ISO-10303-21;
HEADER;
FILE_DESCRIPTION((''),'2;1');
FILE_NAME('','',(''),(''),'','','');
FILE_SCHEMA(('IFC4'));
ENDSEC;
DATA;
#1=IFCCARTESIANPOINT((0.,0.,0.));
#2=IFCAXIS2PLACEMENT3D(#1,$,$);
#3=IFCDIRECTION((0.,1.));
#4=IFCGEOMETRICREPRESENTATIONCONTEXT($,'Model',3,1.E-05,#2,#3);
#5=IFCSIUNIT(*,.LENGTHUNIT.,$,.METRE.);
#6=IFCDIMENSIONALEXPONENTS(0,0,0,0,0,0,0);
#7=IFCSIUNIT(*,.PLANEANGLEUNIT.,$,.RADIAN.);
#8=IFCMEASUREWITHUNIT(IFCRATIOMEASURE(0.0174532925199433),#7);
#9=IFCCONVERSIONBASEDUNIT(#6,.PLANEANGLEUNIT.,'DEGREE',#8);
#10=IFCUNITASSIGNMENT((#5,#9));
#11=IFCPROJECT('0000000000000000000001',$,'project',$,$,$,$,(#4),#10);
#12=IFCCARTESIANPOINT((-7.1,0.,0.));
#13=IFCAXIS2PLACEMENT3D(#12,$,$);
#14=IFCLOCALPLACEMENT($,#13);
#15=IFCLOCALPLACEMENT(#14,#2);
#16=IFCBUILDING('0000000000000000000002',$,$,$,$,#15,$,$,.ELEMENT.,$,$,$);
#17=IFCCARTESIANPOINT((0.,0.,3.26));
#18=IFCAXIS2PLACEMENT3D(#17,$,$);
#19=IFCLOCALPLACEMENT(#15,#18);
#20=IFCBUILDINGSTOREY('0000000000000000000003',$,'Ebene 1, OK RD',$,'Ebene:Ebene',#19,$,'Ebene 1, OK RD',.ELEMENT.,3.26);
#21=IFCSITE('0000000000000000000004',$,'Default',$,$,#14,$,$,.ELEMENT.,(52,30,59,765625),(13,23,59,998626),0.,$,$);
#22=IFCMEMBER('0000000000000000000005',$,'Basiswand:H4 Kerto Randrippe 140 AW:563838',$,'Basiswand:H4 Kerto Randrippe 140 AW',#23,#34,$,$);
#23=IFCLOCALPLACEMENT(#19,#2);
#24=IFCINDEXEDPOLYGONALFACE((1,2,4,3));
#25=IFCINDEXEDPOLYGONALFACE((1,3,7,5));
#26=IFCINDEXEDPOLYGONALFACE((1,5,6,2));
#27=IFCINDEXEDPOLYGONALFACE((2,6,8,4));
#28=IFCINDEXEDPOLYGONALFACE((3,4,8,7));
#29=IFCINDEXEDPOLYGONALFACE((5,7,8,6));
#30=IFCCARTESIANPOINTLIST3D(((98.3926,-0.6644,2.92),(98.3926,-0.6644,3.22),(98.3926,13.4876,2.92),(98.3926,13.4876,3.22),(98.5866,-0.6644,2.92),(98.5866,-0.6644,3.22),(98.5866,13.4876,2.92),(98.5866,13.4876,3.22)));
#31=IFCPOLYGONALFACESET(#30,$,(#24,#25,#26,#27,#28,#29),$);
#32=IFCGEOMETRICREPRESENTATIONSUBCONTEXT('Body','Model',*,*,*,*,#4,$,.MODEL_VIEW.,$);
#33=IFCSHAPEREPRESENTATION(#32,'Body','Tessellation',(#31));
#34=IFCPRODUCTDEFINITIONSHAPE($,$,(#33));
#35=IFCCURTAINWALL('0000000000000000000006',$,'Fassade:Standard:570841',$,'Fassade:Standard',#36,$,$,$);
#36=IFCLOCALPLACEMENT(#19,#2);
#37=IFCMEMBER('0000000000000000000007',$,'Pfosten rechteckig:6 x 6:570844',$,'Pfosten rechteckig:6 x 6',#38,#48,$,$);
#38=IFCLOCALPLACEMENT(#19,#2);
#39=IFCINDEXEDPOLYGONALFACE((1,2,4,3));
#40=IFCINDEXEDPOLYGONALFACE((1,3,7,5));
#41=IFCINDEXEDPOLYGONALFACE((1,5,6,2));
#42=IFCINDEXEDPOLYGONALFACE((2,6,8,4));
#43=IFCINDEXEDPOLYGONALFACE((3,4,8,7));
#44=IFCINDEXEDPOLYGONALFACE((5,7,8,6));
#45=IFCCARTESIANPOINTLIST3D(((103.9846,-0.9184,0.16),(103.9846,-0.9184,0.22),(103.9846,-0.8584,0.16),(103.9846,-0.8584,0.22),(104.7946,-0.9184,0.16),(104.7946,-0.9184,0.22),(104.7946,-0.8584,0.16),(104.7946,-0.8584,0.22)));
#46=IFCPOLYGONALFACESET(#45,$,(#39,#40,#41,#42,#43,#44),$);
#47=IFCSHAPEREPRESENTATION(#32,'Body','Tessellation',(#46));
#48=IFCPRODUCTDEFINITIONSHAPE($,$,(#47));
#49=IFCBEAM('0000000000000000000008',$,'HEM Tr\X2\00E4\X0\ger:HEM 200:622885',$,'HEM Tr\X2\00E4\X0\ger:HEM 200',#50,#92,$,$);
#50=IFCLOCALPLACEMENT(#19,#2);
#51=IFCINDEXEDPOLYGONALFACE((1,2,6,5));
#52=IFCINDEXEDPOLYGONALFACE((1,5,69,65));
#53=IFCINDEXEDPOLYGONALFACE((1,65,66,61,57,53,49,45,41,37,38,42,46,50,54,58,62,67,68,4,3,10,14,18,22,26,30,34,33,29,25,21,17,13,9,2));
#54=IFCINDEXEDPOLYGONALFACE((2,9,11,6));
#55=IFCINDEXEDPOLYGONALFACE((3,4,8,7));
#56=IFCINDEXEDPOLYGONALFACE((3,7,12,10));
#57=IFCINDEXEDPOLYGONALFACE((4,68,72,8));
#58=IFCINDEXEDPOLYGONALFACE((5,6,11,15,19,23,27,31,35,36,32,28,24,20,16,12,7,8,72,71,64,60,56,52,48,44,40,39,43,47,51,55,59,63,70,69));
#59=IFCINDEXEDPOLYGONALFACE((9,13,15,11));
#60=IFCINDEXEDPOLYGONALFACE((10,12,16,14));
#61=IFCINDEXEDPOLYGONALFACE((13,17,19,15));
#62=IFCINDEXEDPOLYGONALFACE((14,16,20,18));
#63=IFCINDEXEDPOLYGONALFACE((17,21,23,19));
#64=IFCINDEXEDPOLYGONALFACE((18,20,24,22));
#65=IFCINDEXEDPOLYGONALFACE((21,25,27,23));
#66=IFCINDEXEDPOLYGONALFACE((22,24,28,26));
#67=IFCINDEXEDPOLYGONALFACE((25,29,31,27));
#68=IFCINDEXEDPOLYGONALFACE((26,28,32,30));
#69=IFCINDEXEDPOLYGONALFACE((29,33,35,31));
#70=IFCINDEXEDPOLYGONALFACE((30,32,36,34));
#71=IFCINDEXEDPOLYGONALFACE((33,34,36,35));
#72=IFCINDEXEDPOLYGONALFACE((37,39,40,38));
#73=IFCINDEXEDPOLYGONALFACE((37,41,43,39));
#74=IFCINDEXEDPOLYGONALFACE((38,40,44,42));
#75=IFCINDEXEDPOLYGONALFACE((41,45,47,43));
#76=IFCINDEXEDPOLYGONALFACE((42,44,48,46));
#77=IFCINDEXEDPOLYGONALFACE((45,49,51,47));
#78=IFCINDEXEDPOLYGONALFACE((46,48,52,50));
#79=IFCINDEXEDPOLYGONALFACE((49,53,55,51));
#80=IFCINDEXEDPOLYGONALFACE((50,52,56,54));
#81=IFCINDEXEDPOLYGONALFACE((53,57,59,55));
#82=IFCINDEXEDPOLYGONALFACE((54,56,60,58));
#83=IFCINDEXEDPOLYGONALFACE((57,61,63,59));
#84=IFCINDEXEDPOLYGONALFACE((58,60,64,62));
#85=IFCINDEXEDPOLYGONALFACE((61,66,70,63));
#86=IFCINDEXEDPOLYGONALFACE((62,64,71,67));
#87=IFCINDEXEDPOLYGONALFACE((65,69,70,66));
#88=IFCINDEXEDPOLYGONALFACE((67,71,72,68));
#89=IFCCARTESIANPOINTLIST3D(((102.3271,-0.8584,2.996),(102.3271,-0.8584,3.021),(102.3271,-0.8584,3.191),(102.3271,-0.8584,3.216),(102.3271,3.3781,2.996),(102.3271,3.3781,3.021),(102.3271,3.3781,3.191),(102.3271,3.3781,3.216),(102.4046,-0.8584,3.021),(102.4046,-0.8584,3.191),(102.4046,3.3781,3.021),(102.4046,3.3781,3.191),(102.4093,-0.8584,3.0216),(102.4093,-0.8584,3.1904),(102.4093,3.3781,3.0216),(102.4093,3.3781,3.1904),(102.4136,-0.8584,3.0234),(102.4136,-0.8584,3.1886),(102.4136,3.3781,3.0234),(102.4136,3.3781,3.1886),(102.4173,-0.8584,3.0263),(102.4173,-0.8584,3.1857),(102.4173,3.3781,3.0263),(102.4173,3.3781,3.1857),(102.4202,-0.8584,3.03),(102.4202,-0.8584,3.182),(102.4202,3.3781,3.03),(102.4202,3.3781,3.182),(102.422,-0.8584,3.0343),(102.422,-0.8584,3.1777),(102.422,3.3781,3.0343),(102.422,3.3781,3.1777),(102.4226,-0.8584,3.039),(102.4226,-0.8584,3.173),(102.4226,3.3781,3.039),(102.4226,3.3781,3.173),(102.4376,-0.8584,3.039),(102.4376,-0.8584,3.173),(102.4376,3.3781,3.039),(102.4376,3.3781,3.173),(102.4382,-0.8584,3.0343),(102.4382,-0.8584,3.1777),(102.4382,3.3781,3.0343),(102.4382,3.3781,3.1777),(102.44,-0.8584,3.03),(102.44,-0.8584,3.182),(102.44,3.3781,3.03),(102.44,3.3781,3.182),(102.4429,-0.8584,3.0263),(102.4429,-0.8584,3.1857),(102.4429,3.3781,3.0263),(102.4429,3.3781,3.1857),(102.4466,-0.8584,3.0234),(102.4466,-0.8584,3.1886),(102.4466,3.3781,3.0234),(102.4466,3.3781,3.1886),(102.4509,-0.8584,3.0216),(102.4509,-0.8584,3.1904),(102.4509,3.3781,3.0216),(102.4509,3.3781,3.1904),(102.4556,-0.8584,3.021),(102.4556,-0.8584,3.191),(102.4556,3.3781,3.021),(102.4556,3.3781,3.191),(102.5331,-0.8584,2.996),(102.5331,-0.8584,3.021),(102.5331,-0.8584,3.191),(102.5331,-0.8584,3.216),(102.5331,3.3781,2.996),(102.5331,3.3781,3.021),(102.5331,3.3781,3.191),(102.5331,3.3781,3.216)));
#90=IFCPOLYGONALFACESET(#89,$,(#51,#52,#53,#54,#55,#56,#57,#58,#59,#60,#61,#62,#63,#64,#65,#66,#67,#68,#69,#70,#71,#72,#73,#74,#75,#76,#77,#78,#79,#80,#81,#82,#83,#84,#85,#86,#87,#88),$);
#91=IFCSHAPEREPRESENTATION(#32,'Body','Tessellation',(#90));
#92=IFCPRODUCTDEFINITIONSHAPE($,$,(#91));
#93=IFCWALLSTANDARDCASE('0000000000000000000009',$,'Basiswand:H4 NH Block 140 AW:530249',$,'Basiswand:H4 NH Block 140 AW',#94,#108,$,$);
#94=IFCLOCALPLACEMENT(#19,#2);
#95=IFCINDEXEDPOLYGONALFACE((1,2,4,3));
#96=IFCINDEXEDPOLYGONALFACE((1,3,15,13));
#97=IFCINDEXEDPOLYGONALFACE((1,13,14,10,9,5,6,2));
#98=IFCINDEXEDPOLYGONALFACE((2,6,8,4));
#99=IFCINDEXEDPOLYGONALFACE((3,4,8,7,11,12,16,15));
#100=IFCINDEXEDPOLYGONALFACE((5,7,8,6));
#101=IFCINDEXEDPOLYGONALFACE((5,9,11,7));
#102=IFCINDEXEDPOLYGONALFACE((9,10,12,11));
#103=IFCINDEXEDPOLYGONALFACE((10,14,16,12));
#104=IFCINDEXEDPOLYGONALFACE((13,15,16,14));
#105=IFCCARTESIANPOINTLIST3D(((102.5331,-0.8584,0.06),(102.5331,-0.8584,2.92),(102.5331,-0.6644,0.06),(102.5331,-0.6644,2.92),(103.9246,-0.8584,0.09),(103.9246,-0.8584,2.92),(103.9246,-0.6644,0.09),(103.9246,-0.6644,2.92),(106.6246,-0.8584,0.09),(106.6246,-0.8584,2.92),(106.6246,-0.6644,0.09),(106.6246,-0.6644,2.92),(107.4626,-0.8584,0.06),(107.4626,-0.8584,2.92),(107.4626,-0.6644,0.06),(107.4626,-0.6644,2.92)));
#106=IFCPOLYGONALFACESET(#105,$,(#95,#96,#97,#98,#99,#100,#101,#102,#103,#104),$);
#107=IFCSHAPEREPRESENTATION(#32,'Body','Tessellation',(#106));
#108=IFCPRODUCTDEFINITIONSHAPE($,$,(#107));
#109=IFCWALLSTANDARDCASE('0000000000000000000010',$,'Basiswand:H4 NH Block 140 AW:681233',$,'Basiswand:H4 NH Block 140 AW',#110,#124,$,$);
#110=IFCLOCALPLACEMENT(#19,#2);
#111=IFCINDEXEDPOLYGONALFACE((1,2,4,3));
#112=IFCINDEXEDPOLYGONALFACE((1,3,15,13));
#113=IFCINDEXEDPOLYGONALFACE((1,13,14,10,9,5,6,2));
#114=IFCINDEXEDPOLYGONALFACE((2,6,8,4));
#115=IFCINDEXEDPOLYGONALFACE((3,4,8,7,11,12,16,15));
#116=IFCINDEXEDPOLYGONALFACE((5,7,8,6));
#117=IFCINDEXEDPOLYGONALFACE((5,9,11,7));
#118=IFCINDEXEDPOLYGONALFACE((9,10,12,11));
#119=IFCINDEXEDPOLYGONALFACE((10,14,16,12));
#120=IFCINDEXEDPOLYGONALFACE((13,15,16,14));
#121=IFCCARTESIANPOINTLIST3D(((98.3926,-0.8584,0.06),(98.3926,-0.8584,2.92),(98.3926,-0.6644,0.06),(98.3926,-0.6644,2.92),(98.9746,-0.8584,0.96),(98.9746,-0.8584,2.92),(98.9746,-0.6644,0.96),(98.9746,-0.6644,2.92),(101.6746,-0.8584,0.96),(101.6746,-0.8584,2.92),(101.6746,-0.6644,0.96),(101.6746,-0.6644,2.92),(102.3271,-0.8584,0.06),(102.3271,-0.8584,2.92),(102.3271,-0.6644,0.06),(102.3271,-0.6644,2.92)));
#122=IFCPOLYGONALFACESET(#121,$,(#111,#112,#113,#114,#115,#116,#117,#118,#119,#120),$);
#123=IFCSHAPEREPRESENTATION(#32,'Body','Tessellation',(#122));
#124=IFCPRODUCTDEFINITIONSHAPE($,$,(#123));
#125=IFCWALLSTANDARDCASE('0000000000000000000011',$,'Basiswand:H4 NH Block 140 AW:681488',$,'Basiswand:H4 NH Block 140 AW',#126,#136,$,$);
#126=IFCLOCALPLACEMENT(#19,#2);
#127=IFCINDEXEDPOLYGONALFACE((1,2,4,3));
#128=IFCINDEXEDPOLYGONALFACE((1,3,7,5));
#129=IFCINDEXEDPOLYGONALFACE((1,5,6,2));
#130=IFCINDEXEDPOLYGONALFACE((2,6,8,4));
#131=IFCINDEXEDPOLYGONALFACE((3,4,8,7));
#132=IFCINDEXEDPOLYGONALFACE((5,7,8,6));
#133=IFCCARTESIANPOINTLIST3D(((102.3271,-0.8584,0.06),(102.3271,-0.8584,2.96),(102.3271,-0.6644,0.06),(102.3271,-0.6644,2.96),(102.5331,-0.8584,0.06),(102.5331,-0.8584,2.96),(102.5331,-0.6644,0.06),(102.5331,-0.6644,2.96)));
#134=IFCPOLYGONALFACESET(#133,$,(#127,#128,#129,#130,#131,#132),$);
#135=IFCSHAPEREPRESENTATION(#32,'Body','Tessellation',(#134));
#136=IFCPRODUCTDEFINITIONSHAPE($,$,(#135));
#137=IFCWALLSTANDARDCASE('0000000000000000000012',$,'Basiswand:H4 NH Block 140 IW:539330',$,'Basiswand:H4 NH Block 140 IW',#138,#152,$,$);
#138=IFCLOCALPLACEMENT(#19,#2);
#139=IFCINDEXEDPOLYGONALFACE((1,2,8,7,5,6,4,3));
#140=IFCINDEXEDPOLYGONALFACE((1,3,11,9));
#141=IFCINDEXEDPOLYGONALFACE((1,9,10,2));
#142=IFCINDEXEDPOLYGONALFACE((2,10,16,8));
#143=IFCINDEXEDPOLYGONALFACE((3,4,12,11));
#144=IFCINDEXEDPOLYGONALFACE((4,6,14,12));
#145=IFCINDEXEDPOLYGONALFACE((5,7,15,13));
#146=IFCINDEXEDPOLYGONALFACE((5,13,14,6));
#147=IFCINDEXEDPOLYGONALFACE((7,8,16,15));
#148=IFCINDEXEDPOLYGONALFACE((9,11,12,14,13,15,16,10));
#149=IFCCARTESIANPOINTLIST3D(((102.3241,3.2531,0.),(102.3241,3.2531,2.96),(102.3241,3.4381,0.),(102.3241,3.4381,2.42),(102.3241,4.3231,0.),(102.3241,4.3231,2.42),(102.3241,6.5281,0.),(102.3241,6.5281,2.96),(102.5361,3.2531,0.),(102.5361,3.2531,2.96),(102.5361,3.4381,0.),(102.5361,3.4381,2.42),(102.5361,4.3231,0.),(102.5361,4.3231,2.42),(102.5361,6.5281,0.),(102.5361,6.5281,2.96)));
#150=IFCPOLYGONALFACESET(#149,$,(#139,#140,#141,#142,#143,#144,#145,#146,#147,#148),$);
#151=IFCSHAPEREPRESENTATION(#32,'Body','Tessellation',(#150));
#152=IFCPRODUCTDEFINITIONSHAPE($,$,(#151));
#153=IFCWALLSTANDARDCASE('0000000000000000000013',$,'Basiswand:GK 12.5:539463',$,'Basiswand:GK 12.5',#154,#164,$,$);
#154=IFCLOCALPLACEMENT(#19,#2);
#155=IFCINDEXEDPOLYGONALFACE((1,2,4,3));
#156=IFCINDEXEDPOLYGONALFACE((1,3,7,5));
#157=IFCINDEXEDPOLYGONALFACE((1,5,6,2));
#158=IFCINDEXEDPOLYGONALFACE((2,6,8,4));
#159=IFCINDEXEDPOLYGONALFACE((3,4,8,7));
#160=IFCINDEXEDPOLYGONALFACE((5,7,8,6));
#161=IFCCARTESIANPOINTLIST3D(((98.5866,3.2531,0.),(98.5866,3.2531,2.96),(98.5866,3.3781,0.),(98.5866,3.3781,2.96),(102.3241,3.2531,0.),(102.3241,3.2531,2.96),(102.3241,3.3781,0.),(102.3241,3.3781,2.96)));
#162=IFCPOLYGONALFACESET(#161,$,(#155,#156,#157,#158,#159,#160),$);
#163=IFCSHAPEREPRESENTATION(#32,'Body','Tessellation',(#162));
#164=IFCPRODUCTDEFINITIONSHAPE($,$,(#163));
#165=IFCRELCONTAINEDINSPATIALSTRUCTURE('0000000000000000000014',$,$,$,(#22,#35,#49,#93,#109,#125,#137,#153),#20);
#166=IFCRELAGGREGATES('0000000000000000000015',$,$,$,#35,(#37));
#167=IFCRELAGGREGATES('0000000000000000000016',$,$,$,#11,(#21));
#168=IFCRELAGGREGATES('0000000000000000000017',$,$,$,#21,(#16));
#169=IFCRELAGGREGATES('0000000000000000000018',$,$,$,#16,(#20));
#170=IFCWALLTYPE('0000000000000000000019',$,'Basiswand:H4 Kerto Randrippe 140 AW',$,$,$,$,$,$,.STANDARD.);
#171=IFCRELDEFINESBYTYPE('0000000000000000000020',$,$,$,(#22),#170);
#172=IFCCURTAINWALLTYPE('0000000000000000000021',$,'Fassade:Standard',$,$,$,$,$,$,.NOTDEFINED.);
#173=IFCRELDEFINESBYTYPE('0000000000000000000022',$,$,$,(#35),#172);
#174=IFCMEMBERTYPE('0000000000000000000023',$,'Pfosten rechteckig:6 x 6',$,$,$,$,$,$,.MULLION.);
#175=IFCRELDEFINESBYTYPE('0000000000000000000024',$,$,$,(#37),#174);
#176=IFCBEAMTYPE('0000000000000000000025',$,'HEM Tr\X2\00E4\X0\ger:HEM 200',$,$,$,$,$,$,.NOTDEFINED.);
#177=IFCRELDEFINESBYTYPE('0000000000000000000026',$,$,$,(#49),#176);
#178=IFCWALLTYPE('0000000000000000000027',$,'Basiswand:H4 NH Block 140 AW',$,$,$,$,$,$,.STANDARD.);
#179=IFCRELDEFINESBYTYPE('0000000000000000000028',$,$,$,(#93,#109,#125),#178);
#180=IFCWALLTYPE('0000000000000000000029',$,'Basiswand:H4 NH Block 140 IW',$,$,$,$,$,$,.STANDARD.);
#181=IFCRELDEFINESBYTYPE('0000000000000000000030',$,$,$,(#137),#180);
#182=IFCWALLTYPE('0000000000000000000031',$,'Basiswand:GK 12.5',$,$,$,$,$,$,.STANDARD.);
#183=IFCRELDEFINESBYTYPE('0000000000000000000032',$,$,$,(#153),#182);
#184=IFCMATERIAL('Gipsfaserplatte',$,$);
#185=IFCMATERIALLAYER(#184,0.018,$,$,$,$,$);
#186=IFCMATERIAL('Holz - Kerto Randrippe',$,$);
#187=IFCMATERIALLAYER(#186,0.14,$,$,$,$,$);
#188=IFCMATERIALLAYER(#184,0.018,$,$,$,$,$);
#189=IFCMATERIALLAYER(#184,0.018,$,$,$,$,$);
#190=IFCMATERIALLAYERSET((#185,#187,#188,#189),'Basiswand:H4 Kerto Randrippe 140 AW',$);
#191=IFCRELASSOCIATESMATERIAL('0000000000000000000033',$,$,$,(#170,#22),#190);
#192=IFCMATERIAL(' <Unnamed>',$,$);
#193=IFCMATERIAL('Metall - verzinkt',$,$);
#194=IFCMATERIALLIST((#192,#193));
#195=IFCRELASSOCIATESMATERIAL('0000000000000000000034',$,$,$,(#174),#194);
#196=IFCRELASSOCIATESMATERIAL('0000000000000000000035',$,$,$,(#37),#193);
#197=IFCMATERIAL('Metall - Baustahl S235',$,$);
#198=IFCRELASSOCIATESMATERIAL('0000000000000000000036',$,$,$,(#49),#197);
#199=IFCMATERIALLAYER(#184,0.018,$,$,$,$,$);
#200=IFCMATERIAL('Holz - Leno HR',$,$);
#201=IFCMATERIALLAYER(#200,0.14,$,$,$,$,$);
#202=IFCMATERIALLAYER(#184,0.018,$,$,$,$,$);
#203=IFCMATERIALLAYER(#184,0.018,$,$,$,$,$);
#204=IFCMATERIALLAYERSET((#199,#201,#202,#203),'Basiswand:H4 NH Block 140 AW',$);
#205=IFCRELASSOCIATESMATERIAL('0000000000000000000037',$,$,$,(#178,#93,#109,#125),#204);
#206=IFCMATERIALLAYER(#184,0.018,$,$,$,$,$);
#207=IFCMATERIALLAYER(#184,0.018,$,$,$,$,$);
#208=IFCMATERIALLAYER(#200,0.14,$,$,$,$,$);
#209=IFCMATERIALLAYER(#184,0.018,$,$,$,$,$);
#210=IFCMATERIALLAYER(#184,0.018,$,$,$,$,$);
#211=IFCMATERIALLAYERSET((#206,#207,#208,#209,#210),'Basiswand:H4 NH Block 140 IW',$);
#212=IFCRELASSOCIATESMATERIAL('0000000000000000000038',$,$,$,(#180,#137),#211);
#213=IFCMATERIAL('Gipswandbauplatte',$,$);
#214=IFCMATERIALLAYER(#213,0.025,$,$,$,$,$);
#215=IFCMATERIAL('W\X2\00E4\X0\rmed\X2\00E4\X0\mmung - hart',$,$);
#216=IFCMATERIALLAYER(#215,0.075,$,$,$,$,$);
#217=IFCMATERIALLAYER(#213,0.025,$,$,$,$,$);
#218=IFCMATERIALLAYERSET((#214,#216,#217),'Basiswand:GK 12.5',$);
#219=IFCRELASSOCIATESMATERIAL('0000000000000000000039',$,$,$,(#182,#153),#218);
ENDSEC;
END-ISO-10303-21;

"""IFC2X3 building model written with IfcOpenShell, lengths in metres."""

from ifc_helpers import new_model, entity, si_unit, converted_unit, direction, frame, frame_2d, origin, origin_2d_with_axis, place, context, subcontext, project, spatial, rectangle, i_section, extrude, source, transform, mapped, material, material_list, layer, layer_set, layer_usage, type_object, type_shapes, element, aggregate, save


model = new_model("IFC2X3")

# Units and contexts
model_context = context("Model", 3, precision=1e-05, world=origin(), true_north=direction((0.0, 1.0)))
body_context = subcontext(model_context, "Body", "Model", "MODEL_VIEW")
ifc_project = project(units=[si_unit("LENGTHUNIT", "METRE"), converted_unit("PLANEANGLEUNIT", "DEGREE", entity("IfcRatioMeasure", 0.0174532925199433), si_unit("PLANEANGLEUNIT", "RADIAN"), dimensions=[0, 0, 0, 0, 0, 0, 0])], contexts=[model_context])

# Site, building, storey
site_placement = place(None, frame((-7.1, 0.0, 0.0)))
site = spatial("IfcSite", under=ifc_project, at=site_placement, Name="Default", CompositionType="ELEMENT", RefLatitude=(52, 30, 59, 765625), RefLongitude=(13, 23, 59, 998626), RefElevation=0.0)
building_placement = place(site_placement, origin())
building = spatial("IfcBuilding", under=site, at=building_placement, CompositionType="ELEMENT")
storey_placement = place(building_placement, frame((0.0, 0.0, 3.26)))
storey = spatial("IfcBuildingStorey", under=building, at=storey_placement, Name="Ebene 1, OK RD", ObjectType="Ebene:Ebene", LongName="Ebene 1, OK RD", CompositionType="ELEMENT", Elevation=3.26)

# Member
ifc_material_1 = material(Name="Gipsfaserplatte")
ifc_layer_1 = layer(ifc_material_1, 0.018)
ifc_material_2 = material(Name="Holz - Kerto Randrippe")
ifc_layer_2 = layer(ifc_material_2, 0.14)
ifc_layer_3 = layer(ifc_material_1, 0.018)
ifc_layer_4 = layer(ifc_material_1, 0.018)
ifc_layer_set_1 = layer_set([ifc_layer_1, ifc_layer_2, ifc_layer_3, ifc_layer_4], Name="Basiswand:H4 Kerto Randrippe 140 AW")
ifc_layer_usage_1 = layer_usage(ifc_layer_set_1, "AXIS2", "NEGATIVE", 0.097)
wall_type_1 = type_object("IfcWallType", Name="Basiswand:H4 Kerto Randrippe 140 AW", PredefinedType="STANDARD", material=ifc_layer_set_1)
member_1_placement = place(storey_placement, frame((98.4896, -0.6644, 2.92), z_axis=(0.0, 0.0, 1.0), x_axis=(0.0, 1.0, 0.0)))
element("IfcMember", 1, at=member_1_placement, inside=storey, type_object=wall_type_1, material=ifc_layer_usage_1, Name="Basiswand:H4 Kerto Randrippe 140 AW:563838", ObjectType="Basiswand:H4 Kerto Randrippe 140 AW", context=body_context, shape_type="SweptSolid", body=[
    extrude(rectangle(XDim=14.152, YDim=0.194, at=frame_2d((7.076, 0.0), x_axis=(-1.0, 0.0))), origin(), (0.0, 0.0, 1.0), 0.3),
])

# Curtain wall, member
curtain_wall_type = type_object("IfcCurtainWallType", Name="Fassade:Standard", PredefinedType="NOTDEFINED")
curtain_wall_placement = place(storey_placement, frame((0.0, 0.0, -3.26)))
curtain_wall = element("IfcCurtainWall", 2, at=curtain_wall_placement, inside=storey, type_object=curtain_wall_type, Name="Fassade:Standard:570841", ObjectType="Fassade:Standard")
ifc_material_3 = material(Name="Metall - verzinkt")
ifc_material_4 = material(Name=" <Unnamed>")
ifc_material_list = material_list([ifc_material_4, ifc_material_3])
member_type = type_object("IfcMemberType", Name="Pfosten rechteckig:6 x 6", PredefinedType="MULLION", material=ifc_material_list)
shared_shape = source(origin(), body_context, "Body", "SweptSolid", [
    extrude(rectangle(XDim=0.06, YDim=0.06, at=origin_2d_with_axis()), frame((-0.03, 0.0, -0.81), z_axis=(0.0, 0.0, 1.0), x_axis=(0.0, -1.0, 0.0)), (0.0, 0.0, 1.0), 0.81),
])
type_shapes(member_type, [shared_shape])
member_2_placement = place(storey_placement, frame((103.9846, -0.8884, 0.16), z_axis=(-1.0, 0.0, 0.0), x_axis=(0.0, 0.0, -1.0)))
member_2 = element("IfcMember", 3, at=member_2_placement, type_object=member_type, material=ifc_material_3, Name="Pfosten rechteckig:6 x 6:570844", ObjectType="Pfosten rechteckig:6 x 6", context=body_context, shape_type="MappedRepresentation", body=[
    mapped(shared_shape, transform((0.0, 0.0, 0.0), scale=1.0)),
])
aggregate(curtain_wall, [member_2])

# Beam
ifc_material_5 = material(Name="Metall - Baustahl S235")
beam_type = type_object("IfcBeamType", Name="HEM Träger:HEM 200", PredefinedType="NOTDEFINED")
beam_placement = place(storey_placement, frame((102.4301, -0.8404, 2.996), z_axis=(0.0, 0.0, 1.0), x_axis=(0.0, 1.0, 0.0)))
element("IfcBeam", 4, at=beam_placement, inside=storey, type_object=beam_type, material=ifc_material_5, Name="HEM Träger:HEM 200:622885", ObjectType="HEM Träger:HEM 200", context=body_context, shape_type="SweptSolid", body=[
    extrude(i_section(OverallWidth=0.206, OverallDepth=0.22, WebThickness=0.015, FlangeThickness=0.025, FilletRadius=0.018, at=frame_2d((0.0, 0.0), x_axis=(0.0, 1.0))), frame((-0.018, 0.0, 0.11), z_axis=(1.0, 0.0, 0.0), x_axis=(0.0, 0.0, -1.0)), (0.0, 0.0, 1.0), 4.2365),
])

# Walls, openings
ifc_layer_5 = layer(ifc_material_1, 0.018)
ifc_material_6 = material(Name="Holz - Leno HR")
ifc_layer_6 = layer(ifc_material_6, 0.14)
ifc_layer_7 = layer(ifc_material_1, 0.018)
ifc_layer_8 = layer(ifc_material_1, 0.018)
ifc_layer_set_2 = layer_set([ifc_layer_5, ifc_layer_6, ifc_layer_7, ifc_layer_8], Name="Basiswand:H4 NH Block 140 AW")
ifc_layer_usage_2 = layer_usage(ifc_layer_set_2, "AXIS2", "NEGATIVE", 0.097)
wall_type_2 = type_object("IfcWallType", Name="Basiswand:H4 NH Block 140 AW", PredefinedType="STANDARD", material=ifc_layer_set_2)
wall_1_placement = place(storey_placement, frame((107.4626, -0.7614, 0.06), z_axis=(0.0, 0.0, 1.0), x_axis=(-1.0, 0.0, 0.0)))
wall_1 = element("IfcWallStandardCase", 5, at=wall_1_placement, inside=storey, type_object=wall_type_2, material=ifc_layer_usage_2, Name="Basiswand:H4 NH Block 140 AW:530249", ObjectType="Basiswand:H4 NH Block 140 AW", context=body_context, shape_type="SweptSolid", body=[
    extrude(rectangle(XDim=4.9295, YDim=0.194, at=frame_2d((2.4648, 0.0), x_axis=(-1.0, 0.0))), origin(), (0.0, 0.0, 1.0), 2.86),
])
opening_1_placement = place(wall_1_placement, origin())
element("IfcOpeningElement", 6, at=opening_1_placement, cuts=wall_1, ObjectType="Opening", context=body_context, shape_type="SweptSolid", body=[
    extrude(rectangle(XDim=2.87, YDim=2.7, at=frame_2d((0.0, 0.0), x_axis=(1.0, 0.0))), frame((2.188, -0.097, 1.465), z_axis=(0.0, 1.0, 0.0), x_axis=(0.0, 0.0, -1.0)), (0.0, 0.0, 1.0), 0.194),
])
ifc_layer_usage_3 = layer_usage(ifc_layer_set_2, "AXIS2", "NEGATIVE", 0.097)
wall_2_placement = place(storey_placement, frame((102.3271, -0.7614, 0.06), z_axis=(0.0, 0.0, 1.0), x_axis=(-1.0, 0.0, 0.0)))
wall_2 = element("IfcWallStandardCase", 7, at=wall_2_placement, inside=storey, type_object=wall_type_2, material=ifc_layer_usage_3, Name="Basiswand:H4 NH Block 140 AW:681233", ObjectType="Basiswand:H4 NH Block 140 AW", context=body_context, shape_type="SweptSolid", body=[
    extrude(rectangle(XDim=3.9345, YDim=0.194, at=frame_2d((1.9673, 0.0), x_axis=(-1.0, 0.0))), origin(), (0.0, 0.0, 1.0), 2.86),
])
opening_2_placement = place(wall_2_placement, origin())
element("IfcOpeningElement", 8, at=opening_2_placement, cuts=wall_2, ObjectType="Opening", context=body_context, shape_type="SweptSolid", body=[
    extrude(rectangle(XDim=2.0, YDim=2.7, at=origin_2d_with_axis()), frame((2.0025, -0.097, 1.9), z_axis=(0.0, 1.0, 0.0), x_axis=(0.0, 0.0, -1.0)), (0.0, 0.0, 1.0), 0.194),
])

# Wall
ifc_layer_usage_4 = layer_usage(ifc_layer_set_2, "AXIS2", "NEGATIVE", 0.097)
wall_3_placement = place(storey_placement, frame((102.5331, -0.7614, 0.06), z_axis=(0.0, 0.0, 1.0), x_axis=(-1.0, 0.0, 0.0)))
element("IfcWallStandardCase", 9, at=wall_3_placement, inside=storey, type_object=wall_type_2, material=ifc_layer_usage_4, Name="Basiswand:H4 NH Block 140 AW:681488", ObjectType="Basiswand:H4 NH Block 140 AW", context=body_context, shape_type="SweptSolid", body=[
    extrude(rectangle(XDim=0.206, YDim=0.194, at=frame_2d((0.103, 0.0), x_axis=(-1.0, 0.0))), origin(), (0.0, 0.0, 1.0), 2.9),
])

# Wall, opening
ifc_layer_9 = layer(ifc_material_1, 0.018)
ifc_layer_10 = layer(ifc_material_1, 0.018)
ifc_layer_11 = layer(ifc_material_6, 0.14)
ifc_layer_12 = layer(ifc_material_1, 0.018)
ifc_layer_13 = layer(ifc_material_1, 0.018)
ifc_layer_set_3 = layer_set([ifc_layer_9, ifc_layer_10, ifc_layer_11, ifc_layer_12, ifc_layer_13], Name="Basiswand:H4 NH Block 140 IW")
ifc_layer_usage_5 = layer_usage(ifc_layer_set_3, "AXIS2", "NEGATIVE", 0.106)
wall_type_3 = type_object("IfcWallType", Name="Basiswand:H4 NH Block 140 IW", PredefinedType="STANDARD", material=ifc_layer_set_3)
wall_4_placement = place(storey_placement, frame((102.4301, 6.5281, 0.0), z_axis=(0.0, 0.0, 1.0), x_axis=(0.0, -1.0, 0.0)))
wall_4 = element("IfcWallStandardCase", 10, at=wall_4_placement, inside=storey, type_object=wall_type_3, material=ifc_layer_usage_5, Name="Basiswand:H4 NH Block 140 IW:539330", ObjectType="Basiswand:H4 NH Block 140 IW", context=body_context, shape_type="SweptSolid", body=[
    extrude(rectangle(XDim=3.275, YDim=0.212, at=frame_2d((1.6375, 0.0), x_axis=(-1.0, 0.0))), origin(), (0.0, 0.0, 1.0), 2.96),
])
opening_3_placement = place(wall_4_placement, frame((3.09, 0.106, 0.0)))
element("IfcOpeningElement", 11, at=opening_3_placement, cuts=wall_4, ObjectType="Opening", context=body_context, shape_type="SweptSolid", body=[
    extrude(rectangle(XDim=2.42, YDim=0.885, at=frame_2d((1.21, 0.4425), x_axis=(1.0, 0.0))), frame((0.0, 0.0, 0.0), z_axis=(0.0, -1.0, 0.0), x_axis=(0.0, 0.0, 1.0)), (0.0, 0.0, 1.0), 0.212),
])

# Wall
ifc_material_7 = material(Name="Gipswandbauplatte")
ifc_layer_14 = layer(ifc_material_7, 0.025)
ifc_material_8 = material(Name="Wärmedämmung - hart")
ifc_layer_15 = layer(ifc_material_8, 0.075)
ifc_layer_16 = layer(ifc_material_7, 0.025)
ifc_layer_set_4 = layer_set([ifc_layer_14, ifc_layer_15, ifc_layer_16], Name="Basiswand:GK 12.5")
ifc_layer_usage_6 = layer_usage(ifc_layer_set_4, "AXIS2", "NEGATIVE", 0.0625)
wall_type_4 = type_object("IfcWallType", Name="Basiswand:GK 12.5", PredefinedType="STANDARD", material=ifc_layer_set_4)
wall_5_placement = place(storey_placement, frame((98.5866, 3.3156, 0.0)))
element("IfcWallStandardCase", 12, at=wall_5_placement, inside=storey, type_object=wall_type_4, material=ifc_layer_usage_6, Name="Basiswand:GK 12.5:539463", ObjectType="Basiswand:GK 12.5", context=body_context, shape_type="SweptSolid", body=[
    extrude(rectangle(XDim=3.7375, YDim=0.125, at=frame_2d((1.8687, 0.0), x_axis=(-1.0, 0.0))), origin(), (0.0, 0.0, 1.0), 2.96),
])

save(model, "model.ifc")
